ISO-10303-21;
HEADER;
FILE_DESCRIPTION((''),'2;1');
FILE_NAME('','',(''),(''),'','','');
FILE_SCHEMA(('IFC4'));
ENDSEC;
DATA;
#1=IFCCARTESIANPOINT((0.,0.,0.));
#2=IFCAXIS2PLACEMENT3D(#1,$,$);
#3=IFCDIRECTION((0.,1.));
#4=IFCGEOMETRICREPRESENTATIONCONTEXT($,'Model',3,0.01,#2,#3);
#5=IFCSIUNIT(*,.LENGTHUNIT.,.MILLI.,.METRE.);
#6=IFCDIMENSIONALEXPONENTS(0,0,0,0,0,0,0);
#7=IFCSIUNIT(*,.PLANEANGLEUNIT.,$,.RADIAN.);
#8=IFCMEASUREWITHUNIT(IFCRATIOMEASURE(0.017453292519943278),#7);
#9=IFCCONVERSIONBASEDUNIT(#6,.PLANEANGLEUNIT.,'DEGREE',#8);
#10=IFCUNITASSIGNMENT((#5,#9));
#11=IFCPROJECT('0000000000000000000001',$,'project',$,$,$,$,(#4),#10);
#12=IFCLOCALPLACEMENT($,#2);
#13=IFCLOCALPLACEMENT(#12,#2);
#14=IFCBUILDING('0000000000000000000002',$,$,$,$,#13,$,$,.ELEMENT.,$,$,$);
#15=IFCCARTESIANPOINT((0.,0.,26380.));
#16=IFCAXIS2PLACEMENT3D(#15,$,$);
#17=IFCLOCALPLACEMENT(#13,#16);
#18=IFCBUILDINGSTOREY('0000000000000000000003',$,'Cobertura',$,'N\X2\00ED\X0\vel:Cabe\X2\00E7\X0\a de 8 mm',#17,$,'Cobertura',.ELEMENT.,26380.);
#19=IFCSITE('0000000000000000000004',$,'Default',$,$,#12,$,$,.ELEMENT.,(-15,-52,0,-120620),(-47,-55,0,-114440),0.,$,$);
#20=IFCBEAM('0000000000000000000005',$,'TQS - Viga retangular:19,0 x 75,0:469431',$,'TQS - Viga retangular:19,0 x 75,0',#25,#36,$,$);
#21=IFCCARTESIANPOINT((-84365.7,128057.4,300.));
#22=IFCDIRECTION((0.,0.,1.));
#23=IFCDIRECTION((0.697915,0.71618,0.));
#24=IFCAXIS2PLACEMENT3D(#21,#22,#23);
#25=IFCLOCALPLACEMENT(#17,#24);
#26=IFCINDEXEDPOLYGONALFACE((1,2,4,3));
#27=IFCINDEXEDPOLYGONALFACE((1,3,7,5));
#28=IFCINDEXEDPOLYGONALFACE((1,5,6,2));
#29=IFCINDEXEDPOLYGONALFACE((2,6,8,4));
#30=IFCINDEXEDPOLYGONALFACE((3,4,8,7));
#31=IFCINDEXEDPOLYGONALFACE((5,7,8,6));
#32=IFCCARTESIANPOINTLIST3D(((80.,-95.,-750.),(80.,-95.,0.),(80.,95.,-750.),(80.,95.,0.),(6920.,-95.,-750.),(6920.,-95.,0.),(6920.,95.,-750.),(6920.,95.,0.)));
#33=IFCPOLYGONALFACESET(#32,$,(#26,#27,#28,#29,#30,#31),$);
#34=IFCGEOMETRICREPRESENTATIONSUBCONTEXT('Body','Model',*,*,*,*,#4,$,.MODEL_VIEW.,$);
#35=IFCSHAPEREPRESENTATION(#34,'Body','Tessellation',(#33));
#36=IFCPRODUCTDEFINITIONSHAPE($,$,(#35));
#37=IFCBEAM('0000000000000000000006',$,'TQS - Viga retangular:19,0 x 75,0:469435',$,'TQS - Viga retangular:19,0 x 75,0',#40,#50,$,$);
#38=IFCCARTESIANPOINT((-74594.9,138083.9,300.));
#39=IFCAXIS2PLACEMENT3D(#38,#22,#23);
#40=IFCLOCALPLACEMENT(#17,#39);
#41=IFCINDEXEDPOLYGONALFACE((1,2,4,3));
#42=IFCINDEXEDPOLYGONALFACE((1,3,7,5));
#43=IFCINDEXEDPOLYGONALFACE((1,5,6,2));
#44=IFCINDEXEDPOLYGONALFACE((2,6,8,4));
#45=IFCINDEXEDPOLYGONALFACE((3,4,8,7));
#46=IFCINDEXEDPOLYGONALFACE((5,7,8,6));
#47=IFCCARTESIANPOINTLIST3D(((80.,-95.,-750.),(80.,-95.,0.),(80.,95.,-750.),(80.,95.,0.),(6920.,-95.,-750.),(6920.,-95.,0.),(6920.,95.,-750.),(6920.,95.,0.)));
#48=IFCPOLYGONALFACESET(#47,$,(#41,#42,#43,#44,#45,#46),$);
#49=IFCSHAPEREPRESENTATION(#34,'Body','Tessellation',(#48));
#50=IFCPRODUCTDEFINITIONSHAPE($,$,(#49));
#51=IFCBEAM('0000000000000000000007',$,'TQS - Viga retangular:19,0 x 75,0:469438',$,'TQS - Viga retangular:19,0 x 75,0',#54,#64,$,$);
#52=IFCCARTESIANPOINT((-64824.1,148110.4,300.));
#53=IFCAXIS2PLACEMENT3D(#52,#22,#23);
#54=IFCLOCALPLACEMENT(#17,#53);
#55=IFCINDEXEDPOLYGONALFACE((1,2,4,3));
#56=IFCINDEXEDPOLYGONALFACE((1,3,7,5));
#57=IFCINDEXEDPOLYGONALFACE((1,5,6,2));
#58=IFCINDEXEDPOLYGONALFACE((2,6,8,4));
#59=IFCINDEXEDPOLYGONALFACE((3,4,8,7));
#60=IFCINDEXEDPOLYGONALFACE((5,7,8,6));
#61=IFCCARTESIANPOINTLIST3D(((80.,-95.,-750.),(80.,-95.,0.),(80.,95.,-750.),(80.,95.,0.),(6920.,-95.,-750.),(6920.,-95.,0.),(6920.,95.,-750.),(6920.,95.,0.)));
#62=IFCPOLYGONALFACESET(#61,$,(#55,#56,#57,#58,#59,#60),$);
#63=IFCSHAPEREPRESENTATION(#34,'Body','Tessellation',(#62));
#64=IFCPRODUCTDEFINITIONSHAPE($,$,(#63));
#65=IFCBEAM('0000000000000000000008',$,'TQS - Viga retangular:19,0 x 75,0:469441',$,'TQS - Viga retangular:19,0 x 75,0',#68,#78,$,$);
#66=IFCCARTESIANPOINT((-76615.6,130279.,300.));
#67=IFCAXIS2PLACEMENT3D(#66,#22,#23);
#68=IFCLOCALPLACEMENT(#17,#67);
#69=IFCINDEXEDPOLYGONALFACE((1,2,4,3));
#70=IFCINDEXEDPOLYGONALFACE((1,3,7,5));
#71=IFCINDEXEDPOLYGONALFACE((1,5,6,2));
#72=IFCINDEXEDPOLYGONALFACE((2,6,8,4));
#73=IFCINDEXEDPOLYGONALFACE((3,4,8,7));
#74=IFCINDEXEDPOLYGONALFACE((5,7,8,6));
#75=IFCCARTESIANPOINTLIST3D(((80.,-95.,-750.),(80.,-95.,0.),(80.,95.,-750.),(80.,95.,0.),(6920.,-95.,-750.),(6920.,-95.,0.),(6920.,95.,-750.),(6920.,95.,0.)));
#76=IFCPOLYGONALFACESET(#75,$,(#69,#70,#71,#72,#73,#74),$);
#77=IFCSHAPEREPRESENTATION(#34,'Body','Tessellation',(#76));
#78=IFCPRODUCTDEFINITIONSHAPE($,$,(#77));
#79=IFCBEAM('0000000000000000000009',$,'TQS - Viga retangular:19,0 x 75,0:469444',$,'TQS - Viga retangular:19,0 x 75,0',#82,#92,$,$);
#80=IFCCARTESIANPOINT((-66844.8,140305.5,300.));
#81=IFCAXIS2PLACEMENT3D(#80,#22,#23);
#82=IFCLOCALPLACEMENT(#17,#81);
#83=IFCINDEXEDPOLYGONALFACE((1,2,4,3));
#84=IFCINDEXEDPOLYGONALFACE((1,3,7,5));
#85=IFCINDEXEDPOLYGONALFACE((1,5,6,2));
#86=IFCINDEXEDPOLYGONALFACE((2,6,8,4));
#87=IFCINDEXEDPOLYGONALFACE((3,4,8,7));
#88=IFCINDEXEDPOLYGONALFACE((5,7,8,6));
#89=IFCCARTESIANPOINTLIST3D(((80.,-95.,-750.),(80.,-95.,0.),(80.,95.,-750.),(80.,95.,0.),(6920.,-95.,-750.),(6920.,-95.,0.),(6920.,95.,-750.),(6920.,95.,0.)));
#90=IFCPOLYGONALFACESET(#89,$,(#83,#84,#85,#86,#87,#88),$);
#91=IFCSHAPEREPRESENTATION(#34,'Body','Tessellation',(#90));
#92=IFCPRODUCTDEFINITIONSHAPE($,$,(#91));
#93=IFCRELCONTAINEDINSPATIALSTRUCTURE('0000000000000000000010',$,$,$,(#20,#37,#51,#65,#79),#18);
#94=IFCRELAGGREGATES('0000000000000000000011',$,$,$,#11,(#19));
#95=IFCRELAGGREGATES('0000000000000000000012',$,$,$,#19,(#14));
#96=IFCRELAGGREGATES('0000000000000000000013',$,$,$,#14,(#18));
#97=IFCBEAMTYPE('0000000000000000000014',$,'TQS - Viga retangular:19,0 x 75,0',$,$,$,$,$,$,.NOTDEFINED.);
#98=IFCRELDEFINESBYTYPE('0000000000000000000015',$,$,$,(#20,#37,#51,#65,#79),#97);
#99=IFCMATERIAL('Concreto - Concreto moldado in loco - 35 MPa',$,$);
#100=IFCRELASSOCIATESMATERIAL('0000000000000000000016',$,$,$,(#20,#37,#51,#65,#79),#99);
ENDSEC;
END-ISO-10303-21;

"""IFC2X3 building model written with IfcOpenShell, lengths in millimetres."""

from ifc_helpers import new_model, entity, si_unit, converted_unit, direction, frame, frame_2d, origin, place, context, subcontext, project, spatial, rectangle, extrude, material, type_object, element, save


model = new_model("IFC2X3")

# Units and contexts
model_context = context("Model", 3, precision=0.01, world=origin(), true_north=direction((0.0, 1.0)))
body_context = subcontext(model_context, "Body", "Model", "MODEL_VIEW")
ifc_project = project(units=[si_unit("LENGTHUNIT", "METRE", prefix="MILLI"), converted_unit("PLANEANGLEUNIT", "DEGREE", entity("IfcRatioMeasure", 0.017453292519943278), si_unit("PLANEANGLEUNIT", "RADIAN"), dimensions=[0, 0, 0, 0, 0, 0, 0])], contexts=[model_context])

# Site, building, storey
site_placement = place(None, origin())
site = spatial("IfcSite", under=ifc_project, at=site_placement, Name="Default", CompositionType="ELEMENT", RefLatitude=(-15, -52, 0, -120620), RefLongitude=(-47, -55, 0, -114440), RefElevation=0.0)
building_placement = place(site_placement, origin())
building = spatial("IfcBuilding", under=site, at=building_placement, CompositionType="ELEMENT")
storey_placement = place(building_placement, frame((0.0, 0.0, 26380.0)))
storey = spatial("IfcBuildingStorey", under=building, at=storey_placement, Name="Cobertura", ObjectType="Nível:Cabeça de 8 mm", LongName="Cobertura", CompositionType="ELEMENT", Elevation=26380.0)

# Beams
ifc_material = material(Name="Concreto - Concreto moldado in loco - 35 MPa")
beam_type_1 = type_object("IfcBeamType", Name="TQS - Viga retangular:19,0 x 75,0", PredefinedType="NOTDEFINED")
beam_1_placement = place(storey_placement, frame((-84365.7, 128057.4, 300.0), z_axis=(0.0, 0.0, 1.0), x_axis=(0.697915, 0.71618, 0.0)))
element("IfcBeam", 1, at=beam_1_placement, inside=storey, type_object=beam_type_1, material=ifc_material, Name="TQS - Viga retangular:19,0 x 75,0:469431", ObjectType="TQS - Viga retangular:19,0 x 75,0", context=body_context, shape_type="SweptSolid", body=[
    extrude(rectangle(XDim=750.0, YDim=190.0, at=frame_2d((0.0, 0.0), x_axis=(1.0, 0.0))), frame((80.0, 0.0, -375.0), z_axis=(1.0, 0.0, 0.0), x_axis=(0.0, 0.0, -1.0)), (0.0, 0.0, 1.0), 6840.0),
])
beam_2_placement = place(storey_placement, frame((-74594.9, 138083.9, 300.0), z_axis=(0.0, 0.0, 1.0), x_axis=(0.697915, 0.71618, 0.0)))
element("IfcBeam", 2, at=beam_2_placement, inside=storey, type_object=beam_type_1, material=ifc_material, Name="TQS - Viga retangular:19,0 x 75,0:469435", ObjectType="TQS - Viga retangular:19,0 x 75,0", context=body_context, shape_type="SweptSolid", body=[
    extrude(rectangle(XDim=750.0, YDim=190.0, at=frame_2d((0.0, 0.0), x_axis=(1.0, 0.0))), frame((80.0, 0.0, -375.0), z_axis=(1.0, 0.0, 0.0), x_axis=(0.0, 0.0, -1.0)), (0.0, 0.0, 1.0), 6840.0),
])
beam_3_placement = place(storey_placement, frame((-64824.1, 148110.4, 300.0), z_axis=(0.0, 0.0, 1.0), x_axis=(0.697915, 0.71618, 0.0)))
element("IfcBeam", 3, at=beam_3_placement, inside=storey, type_object=beam_type_1, material=ifc_material, Name="TQS - Viga retangular:19,0 x 75,0:469438", ObjectType="TQS - Viga retangular:19,0 x 75,0", context=body_context, shape_type="SweptSolid", body=[
    extrude(rectangle(XDim=750.0, YDim=190.0, at=frame_2d((0.0, 0.0), x_axis=(1.0, 0.0))), frame((80.0, 0.0, -375.0), z_axis=(1.0, 0.0, 0.0), x_axis=(0.0, 0.0, -1.0)), (0.0, 0.0, 1.0), 6840.0),
])
beam_4_placement = place(storey_placement, frame((-76615.6, 130279.0, 300.0), z_axis=(0.0, 0.0, 1.0), x_axis=(0.697915, 0.71618, 0.0)))
element("IfcBeam", 4, at=beam_4_placement, inside=storey, type_object=beam_type_1, material=ifc_material, Name="TQS - Viga retangular:19,0 x 75,0:469441", ObjectType="TQS - Viga retangular:19,0 x 75,0", context=body_context, shape_type="SweptSolid", body=[
    extrude(rectangle(XDim=750.0, YDim=190.0, at=frame_2d((0.0, 0.0), x_axis=(1.0, 0.0))), frame((80.0, 0.0, -375.0), z_axis=(1.0, 0.0, 0.0), x_axis=(0.0, 0.0, -1.0)), (0.0, 0.0, 1.0), 6840.0),
])
beam_5_placement = place(storey_placement, frame((-66844.8, 140305.5, 300.0), z_axis=(0.0, 0.0, 1.0), x_axis=(0.697915, 0.71618, 0.0)))
element("IfcBeam", 5, at=beam_5_placement, inside=storey, type_object=beam_type_1, material=ifc_material, Name="TQS - Viga retangular:19,0 x 75,0:469444", ObjectType="TQS - Viga retangular:19,0 x 75,0", context=body_context, shape_type="SweptSolid", body=[
    extrude(rectangle(XDim=750.0, YDim=190.0, at=frame_2d((0.0, 0.0), x_axis=(1.0, 0.0))), frame((80.0, 0.0, -375.0), z_axis=(1.0, 0.0, 0.0), x_axis=(0.0, 0.0, -1.0)), (0.0, 0.0, 1.0), 6840.0),
])

save(model, "model.ifc")
